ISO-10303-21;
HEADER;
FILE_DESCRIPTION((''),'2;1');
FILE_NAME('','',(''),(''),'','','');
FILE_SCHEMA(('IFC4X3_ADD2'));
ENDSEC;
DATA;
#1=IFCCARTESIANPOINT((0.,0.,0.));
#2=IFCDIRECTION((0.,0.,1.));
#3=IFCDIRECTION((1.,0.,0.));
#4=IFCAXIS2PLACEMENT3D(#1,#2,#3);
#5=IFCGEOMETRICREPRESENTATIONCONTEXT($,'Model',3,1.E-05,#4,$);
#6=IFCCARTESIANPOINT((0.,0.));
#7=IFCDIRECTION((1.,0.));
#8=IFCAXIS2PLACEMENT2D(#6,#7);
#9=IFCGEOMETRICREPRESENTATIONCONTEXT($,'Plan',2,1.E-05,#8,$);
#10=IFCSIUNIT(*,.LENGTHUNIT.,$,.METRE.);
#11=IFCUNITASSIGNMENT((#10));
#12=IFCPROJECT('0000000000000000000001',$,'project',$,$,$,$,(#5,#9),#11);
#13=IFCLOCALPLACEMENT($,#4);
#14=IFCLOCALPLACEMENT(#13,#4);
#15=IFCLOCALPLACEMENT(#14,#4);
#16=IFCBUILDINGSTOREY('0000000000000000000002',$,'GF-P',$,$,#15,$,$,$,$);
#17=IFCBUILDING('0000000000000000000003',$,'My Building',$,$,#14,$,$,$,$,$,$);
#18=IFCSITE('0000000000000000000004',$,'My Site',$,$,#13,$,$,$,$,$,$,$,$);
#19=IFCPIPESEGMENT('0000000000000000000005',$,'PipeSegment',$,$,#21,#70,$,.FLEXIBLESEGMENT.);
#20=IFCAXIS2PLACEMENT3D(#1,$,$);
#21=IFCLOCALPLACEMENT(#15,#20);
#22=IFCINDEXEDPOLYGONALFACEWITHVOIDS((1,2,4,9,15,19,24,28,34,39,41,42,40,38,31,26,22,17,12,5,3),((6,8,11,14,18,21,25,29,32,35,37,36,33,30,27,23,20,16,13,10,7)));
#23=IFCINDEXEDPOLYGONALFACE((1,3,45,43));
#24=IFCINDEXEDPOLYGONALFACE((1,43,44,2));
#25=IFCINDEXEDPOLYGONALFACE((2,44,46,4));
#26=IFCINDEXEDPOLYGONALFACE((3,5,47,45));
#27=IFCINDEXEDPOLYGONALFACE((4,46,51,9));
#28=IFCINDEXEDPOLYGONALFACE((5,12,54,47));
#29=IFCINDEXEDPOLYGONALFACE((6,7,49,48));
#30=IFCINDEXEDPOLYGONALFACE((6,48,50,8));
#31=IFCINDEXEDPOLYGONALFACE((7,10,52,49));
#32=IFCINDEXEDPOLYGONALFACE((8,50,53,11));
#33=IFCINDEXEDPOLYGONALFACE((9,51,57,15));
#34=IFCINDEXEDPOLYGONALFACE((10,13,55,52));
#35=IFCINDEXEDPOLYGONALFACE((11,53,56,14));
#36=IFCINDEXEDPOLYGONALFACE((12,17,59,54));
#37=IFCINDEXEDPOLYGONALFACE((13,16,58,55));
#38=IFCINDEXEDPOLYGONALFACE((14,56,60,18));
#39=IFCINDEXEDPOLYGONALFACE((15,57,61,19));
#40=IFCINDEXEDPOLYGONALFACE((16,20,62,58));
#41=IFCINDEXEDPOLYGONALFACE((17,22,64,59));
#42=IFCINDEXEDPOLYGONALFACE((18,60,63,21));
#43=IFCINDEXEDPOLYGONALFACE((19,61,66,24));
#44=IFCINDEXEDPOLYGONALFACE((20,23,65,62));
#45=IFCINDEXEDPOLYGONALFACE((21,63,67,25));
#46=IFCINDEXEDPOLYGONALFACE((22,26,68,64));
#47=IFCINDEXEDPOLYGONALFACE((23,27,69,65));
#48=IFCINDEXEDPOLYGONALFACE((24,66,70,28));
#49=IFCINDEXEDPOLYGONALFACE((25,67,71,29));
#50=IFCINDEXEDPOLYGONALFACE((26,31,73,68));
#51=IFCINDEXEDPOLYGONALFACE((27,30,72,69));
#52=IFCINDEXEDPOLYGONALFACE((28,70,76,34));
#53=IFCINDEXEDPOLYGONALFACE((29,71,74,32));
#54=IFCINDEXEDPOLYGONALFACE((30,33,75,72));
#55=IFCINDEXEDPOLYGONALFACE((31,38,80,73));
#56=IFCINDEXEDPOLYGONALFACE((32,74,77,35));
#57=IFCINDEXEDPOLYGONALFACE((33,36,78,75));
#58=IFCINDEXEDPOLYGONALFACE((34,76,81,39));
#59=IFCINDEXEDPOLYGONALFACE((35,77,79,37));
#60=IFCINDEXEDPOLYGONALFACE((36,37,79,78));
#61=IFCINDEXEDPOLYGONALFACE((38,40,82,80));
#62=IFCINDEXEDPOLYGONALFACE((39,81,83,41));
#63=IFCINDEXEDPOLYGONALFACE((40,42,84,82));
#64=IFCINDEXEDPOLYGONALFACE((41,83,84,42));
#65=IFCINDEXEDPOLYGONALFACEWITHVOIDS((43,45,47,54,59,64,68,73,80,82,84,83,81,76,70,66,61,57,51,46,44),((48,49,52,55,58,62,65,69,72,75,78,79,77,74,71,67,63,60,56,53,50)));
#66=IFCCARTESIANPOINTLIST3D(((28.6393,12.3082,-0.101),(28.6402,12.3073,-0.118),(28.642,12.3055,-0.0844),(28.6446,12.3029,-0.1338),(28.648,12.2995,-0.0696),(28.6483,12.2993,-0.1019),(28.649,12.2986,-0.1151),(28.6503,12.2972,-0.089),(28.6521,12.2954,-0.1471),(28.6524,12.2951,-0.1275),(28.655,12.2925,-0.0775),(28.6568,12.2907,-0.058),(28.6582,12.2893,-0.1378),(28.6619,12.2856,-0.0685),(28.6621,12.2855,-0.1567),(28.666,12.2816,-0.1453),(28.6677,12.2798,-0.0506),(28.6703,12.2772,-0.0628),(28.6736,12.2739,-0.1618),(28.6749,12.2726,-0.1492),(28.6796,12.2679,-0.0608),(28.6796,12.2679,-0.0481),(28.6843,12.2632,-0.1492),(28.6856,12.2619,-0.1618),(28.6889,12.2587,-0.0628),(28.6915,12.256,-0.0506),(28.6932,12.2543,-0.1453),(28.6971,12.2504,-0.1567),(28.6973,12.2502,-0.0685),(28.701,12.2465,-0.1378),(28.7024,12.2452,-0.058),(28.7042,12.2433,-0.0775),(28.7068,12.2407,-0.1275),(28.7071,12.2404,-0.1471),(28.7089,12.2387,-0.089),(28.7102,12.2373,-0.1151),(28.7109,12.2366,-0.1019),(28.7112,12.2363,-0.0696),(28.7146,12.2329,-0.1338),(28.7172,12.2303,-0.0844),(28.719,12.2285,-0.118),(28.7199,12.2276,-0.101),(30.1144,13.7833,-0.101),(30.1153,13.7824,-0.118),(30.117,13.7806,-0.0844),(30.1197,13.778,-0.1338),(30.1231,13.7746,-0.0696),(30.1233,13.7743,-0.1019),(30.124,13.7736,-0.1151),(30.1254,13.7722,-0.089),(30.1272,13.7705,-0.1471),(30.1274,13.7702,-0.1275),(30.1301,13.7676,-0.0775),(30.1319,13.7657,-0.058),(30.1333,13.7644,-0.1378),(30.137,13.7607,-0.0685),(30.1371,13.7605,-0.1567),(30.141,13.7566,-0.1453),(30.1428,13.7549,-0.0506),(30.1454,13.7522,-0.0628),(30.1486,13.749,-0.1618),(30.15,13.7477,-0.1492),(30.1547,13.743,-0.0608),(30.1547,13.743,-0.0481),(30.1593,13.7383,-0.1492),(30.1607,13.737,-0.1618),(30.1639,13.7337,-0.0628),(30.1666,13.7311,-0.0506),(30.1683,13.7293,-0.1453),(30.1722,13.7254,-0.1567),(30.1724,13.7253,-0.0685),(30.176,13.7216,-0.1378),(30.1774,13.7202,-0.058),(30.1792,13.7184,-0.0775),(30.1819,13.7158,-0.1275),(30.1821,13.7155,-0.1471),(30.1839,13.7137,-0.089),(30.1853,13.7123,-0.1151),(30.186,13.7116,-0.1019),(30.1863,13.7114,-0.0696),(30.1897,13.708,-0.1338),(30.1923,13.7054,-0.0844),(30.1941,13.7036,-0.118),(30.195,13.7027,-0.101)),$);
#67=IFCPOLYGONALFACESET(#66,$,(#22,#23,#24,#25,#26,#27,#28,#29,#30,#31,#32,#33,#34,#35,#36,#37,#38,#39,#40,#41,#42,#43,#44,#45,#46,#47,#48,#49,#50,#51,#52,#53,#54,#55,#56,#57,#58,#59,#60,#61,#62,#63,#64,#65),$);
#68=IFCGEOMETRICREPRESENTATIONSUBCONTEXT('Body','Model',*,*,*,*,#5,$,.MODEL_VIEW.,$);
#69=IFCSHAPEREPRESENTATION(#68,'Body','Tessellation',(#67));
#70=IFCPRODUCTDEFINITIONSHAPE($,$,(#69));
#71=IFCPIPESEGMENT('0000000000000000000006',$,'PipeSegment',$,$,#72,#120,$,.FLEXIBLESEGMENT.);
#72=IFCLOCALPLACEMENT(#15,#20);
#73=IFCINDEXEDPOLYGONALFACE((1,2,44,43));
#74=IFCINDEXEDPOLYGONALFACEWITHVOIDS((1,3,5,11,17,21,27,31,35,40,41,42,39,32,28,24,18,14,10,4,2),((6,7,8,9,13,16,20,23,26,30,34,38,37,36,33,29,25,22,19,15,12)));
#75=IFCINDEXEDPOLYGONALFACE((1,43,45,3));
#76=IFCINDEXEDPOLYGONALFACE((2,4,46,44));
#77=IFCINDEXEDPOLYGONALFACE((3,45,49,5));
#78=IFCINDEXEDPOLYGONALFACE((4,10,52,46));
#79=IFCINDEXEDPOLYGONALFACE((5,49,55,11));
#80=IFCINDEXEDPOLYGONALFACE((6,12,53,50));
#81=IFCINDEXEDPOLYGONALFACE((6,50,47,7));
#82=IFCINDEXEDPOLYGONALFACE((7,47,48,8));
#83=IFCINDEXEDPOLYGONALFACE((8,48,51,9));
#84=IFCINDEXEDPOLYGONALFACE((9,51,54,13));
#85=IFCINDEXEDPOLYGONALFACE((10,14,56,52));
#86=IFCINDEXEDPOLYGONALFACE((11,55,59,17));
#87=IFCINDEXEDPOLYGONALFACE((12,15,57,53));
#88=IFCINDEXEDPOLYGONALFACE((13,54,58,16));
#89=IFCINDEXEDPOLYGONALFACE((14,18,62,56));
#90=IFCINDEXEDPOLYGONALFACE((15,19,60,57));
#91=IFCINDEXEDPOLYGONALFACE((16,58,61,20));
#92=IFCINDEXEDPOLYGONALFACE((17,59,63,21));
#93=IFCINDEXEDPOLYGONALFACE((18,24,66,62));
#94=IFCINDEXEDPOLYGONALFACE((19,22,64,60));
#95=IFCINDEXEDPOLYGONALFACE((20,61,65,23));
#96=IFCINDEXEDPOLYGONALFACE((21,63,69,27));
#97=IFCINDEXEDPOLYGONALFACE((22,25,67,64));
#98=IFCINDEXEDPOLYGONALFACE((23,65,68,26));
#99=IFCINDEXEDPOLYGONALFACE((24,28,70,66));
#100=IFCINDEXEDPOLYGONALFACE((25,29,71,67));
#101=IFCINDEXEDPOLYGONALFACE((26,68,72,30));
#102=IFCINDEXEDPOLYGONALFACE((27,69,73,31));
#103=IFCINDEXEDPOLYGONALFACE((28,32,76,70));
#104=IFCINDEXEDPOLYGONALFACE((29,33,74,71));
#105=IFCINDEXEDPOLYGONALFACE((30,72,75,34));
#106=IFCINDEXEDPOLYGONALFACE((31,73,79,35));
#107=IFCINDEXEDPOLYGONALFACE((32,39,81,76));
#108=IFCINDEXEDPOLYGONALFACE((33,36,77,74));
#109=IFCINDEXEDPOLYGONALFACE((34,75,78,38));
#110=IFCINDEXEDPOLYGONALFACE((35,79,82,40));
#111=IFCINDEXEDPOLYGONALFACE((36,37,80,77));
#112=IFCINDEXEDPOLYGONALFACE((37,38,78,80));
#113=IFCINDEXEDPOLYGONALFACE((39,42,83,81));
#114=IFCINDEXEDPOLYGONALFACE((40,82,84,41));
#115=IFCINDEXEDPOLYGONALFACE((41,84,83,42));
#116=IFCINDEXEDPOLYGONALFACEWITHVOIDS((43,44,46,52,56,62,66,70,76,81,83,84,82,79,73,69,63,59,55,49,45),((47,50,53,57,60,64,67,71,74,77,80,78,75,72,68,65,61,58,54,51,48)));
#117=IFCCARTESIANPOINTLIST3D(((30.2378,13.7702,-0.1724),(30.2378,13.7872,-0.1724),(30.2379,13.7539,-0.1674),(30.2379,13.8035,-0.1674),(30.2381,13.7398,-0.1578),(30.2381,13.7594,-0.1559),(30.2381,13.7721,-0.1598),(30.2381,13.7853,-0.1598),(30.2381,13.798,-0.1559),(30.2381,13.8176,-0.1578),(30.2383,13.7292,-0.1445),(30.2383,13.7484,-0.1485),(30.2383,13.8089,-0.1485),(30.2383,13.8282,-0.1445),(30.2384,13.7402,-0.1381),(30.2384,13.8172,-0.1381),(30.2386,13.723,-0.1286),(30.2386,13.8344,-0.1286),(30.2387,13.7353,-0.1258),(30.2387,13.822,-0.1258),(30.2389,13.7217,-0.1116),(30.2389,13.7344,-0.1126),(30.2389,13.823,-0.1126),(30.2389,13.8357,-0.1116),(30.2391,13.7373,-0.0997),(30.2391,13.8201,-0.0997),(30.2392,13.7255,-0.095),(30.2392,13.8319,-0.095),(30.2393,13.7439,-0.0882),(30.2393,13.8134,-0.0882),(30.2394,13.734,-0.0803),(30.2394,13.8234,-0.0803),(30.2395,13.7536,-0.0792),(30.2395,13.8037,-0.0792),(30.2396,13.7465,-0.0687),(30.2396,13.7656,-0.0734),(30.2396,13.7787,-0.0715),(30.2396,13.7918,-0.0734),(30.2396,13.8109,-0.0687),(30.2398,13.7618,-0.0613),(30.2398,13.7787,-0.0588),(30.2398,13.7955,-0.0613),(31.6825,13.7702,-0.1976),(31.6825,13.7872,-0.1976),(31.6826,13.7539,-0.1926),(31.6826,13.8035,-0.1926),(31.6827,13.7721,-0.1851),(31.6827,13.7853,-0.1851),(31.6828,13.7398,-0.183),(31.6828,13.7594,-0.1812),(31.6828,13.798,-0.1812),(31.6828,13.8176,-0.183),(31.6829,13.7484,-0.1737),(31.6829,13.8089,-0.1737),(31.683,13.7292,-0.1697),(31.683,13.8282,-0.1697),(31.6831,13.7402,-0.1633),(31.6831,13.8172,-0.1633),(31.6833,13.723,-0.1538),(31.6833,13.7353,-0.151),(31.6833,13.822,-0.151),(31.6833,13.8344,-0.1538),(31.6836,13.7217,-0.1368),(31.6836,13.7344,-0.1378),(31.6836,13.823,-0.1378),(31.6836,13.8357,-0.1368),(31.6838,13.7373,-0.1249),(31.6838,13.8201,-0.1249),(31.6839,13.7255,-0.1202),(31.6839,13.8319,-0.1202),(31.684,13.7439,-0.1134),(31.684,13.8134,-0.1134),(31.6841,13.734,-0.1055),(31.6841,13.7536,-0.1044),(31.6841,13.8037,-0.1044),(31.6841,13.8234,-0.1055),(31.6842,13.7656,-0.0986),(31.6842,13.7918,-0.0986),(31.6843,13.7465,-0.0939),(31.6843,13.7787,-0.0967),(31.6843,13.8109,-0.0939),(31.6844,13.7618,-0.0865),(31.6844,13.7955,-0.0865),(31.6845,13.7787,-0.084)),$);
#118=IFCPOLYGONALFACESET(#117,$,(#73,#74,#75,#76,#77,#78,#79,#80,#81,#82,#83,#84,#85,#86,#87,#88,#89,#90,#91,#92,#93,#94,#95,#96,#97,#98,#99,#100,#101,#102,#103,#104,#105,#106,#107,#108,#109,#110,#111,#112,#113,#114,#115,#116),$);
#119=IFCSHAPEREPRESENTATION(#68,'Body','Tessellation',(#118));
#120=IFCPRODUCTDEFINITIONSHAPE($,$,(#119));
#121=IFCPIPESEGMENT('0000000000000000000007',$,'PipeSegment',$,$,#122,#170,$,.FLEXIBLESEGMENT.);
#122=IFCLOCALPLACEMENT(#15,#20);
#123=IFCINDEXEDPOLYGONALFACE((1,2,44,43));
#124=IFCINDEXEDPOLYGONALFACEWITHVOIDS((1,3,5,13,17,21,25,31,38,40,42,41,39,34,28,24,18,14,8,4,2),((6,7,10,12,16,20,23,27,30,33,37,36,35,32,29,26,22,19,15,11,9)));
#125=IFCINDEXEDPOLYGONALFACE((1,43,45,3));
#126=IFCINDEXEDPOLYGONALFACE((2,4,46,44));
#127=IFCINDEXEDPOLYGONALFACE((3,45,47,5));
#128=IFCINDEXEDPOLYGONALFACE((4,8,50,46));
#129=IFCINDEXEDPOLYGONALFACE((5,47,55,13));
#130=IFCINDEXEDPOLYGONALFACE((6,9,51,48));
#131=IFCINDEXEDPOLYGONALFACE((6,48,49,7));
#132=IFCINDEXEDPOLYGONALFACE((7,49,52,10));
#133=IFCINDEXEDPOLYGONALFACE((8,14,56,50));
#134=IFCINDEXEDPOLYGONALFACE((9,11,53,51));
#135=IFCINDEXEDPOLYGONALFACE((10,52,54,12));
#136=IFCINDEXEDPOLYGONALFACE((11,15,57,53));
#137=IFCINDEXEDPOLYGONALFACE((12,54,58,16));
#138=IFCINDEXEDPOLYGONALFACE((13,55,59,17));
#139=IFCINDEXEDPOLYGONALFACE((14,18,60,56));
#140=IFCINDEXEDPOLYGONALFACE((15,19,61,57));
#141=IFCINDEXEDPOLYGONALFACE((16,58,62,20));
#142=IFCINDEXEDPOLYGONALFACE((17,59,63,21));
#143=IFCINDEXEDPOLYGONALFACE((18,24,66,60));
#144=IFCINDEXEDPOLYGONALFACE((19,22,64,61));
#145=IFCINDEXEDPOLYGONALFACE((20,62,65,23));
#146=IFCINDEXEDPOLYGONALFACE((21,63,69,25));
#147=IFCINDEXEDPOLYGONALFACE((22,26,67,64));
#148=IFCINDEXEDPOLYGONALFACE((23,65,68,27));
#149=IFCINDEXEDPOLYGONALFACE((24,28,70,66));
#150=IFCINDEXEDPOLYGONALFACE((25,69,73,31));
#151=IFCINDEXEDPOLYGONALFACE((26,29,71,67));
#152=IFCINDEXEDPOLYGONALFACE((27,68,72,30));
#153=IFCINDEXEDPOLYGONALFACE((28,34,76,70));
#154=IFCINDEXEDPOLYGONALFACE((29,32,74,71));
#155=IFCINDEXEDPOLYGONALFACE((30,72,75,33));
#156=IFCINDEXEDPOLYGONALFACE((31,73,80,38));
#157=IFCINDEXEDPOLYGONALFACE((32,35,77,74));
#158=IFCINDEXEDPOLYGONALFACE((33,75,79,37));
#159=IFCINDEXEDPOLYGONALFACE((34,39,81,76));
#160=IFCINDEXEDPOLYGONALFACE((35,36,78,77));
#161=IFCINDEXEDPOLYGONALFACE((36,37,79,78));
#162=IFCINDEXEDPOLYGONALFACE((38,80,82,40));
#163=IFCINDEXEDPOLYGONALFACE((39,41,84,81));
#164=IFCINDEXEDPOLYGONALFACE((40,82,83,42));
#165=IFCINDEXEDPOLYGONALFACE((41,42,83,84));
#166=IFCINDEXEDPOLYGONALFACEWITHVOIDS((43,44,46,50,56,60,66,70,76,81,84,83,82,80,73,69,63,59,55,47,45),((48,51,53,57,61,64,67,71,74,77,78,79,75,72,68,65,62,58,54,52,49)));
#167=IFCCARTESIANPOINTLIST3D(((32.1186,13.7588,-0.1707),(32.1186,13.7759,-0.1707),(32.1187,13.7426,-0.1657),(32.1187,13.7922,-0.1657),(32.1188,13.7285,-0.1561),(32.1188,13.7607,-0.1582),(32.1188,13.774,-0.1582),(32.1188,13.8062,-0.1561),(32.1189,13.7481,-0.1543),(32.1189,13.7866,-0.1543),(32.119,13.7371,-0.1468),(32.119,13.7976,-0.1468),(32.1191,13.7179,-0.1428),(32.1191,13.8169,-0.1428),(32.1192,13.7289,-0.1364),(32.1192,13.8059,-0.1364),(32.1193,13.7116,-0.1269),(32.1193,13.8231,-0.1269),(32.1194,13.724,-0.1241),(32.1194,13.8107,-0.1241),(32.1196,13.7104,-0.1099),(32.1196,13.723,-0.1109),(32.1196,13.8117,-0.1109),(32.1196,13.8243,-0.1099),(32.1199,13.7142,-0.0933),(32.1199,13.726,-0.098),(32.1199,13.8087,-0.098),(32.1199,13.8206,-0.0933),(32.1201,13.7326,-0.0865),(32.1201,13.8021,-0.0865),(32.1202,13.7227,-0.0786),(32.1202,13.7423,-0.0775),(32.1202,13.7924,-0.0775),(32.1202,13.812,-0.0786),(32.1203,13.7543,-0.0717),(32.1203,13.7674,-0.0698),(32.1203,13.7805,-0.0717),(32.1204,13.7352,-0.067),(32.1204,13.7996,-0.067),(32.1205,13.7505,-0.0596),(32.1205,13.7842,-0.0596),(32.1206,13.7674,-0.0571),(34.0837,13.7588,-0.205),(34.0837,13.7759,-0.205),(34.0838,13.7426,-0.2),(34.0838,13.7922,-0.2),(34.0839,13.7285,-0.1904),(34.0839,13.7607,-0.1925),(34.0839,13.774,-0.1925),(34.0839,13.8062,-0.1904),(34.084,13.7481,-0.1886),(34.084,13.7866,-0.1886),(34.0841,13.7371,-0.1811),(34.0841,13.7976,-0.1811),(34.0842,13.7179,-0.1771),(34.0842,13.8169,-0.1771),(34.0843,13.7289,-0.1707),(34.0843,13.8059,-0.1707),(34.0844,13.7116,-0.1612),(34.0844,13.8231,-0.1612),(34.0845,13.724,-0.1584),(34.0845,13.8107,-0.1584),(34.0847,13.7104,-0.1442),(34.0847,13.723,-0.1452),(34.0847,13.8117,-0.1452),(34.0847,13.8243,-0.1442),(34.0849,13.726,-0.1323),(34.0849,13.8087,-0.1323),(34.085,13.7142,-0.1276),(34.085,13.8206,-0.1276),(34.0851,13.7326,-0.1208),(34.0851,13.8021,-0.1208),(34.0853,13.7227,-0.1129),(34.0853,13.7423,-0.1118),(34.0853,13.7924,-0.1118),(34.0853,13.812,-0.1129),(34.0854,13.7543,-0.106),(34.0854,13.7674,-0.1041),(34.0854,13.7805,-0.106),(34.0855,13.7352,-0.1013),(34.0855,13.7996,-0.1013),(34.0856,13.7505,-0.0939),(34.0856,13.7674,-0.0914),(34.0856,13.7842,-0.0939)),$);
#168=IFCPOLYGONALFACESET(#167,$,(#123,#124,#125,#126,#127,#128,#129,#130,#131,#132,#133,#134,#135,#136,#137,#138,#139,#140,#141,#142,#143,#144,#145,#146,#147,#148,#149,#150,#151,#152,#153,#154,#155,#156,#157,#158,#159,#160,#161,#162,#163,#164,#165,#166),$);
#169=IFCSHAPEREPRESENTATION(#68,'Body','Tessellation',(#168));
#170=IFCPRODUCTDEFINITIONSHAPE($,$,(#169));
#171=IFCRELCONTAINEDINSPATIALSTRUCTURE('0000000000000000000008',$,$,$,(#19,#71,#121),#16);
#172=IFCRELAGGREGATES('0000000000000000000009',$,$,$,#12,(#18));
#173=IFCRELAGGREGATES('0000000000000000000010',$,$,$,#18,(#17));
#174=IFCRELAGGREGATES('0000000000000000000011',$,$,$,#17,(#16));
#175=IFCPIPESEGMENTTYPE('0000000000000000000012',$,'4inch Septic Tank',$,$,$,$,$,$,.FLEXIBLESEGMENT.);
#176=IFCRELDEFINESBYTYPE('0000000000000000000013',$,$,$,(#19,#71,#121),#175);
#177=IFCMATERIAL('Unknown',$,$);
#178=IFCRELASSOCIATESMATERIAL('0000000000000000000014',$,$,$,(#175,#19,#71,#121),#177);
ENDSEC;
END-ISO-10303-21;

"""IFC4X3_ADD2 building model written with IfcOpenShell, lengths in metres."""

from ifc_helpers import new_model, si_unit, frame, origin_with_axes, origin_2d_with_axis, place, context, subcontext, project, spatial, hollow_circle, extrude, material, material_profile, profile_set, profile_usage, type_object, element, save


model = new_model("IFC4X3_ADD2")

# Units and contexts
model_context = context("Model", 3, precision=1e-05, world=origin_with_axes())
plan_context = context("Plan", 2, precision=1e-05, world=origin_2d_with_axis())
body_context = subcontext(model_context, "Body", "Model", "MODEL_VIEW")
ifc_project = project(units=[si_unit("LENGTHUNIT", "METRE")], contexts=[model_context, plan_context])

# Site, building, storey
site_placement = place(None, origin_with_axes())
site = spatial("IfcSite", under=ifc_project, at=site_placement, Name="My Site")
building_placement = place(site_placement, origin_with_axes())
building = spatial("IfcBuilding", under=site, at=building_placement, Name="My Building")
storey_placement = place(building_placement, origin_with_axes())
storey = spatial("IfcBuildingStorey", under=building, at=storey_placement, Name="GF-P")

# Pipe segments
ifc_material_1 = material(Name="Unknown")
ifc_material_profile_1 = material_profile(ifc_material_1, hollow_circle(Radius=0.0571, WallThickness=0.0127))
ifc_profile_set_1 = profile_set([ifc_material_profile_1], Name="blackwater")
pipe_segment_type_1 = type_object("IfcPipeSegmentType", Name="4inch Septic Tank", PredefinedType="FLEXIBLESEGMENT", material=ifc_profile_set_1)
ifc_profile_usage_1 = profile_usage(ifc_profile_set_1, cardinal=5)
pipe_segment_1_placement = place(storey_placement, frame((28.6796, 12.2679, -0.1052), z_axis=(0.707107, 0.707107, 0.0), x_axis=(0.000001, 0.0, 1.0)))
element("IfcPipeSegment", 1, at=pipe_segment_1_placement, inside=storey, type_object=pipe_segment_type_1, material=ifc_profile_usage_1, Name="PipeSegment", PredefinedType="FLEXIBLESEGMENT", context=body_context, shape_type="SweptSolid", body=[
    extrude(hollow_circle(Radius=0.0571, WallThickness=0.0127), origin_with_axes(), (0.0, 0.0, 1.0), 2.086),
])
ifc_profile_usage_2 = profile_usage(ifc_profile_set_1, cardinal=5)
pipe_segment_2_placement = place(storey_placement, frame((30.2388, 13.7787, -0.1159), z_axis=(0.999848, 0.0, -0.017452), x_axis=(0.017452, 0.0, 0.999848)))
element("IfcPipeSegment", 2, at=pipe_segment_2_placement, inside=storey, type_object=pipe_segment_type_1, material=ifc_profile_usage_2, Name="PipeSegment", PredefinedType="FLEXIBLESEGMENT", context=body_context, shape_type="SweptSolid", body=[
    extrude(hollow_circle(Radius=0.0571, WallThickness=0.0127), origin_with_axes(), (0.0, 0.0, 1.0), 1.4449),
])
ifc_profile_usage_3 = profile_usage(ifc_profile_set_1, cardinal=5)
pipe_segment_3_placement = place(storey_placement, frame((32.1196, 13.7674, -0.1142), z_axis=(0.999848, 0.0, -0.017452), x_axis=(0.017452, 0.0, 0.999848)))
element("IfcPipeSegment", 3, at=pipe_segment_3_placement, inside=storey, type_object=pipe_segment_type_1, material=ifc_profile_usage_3, Name="PipeSegment", PredefinedType="FLEXIBLESEGMENT", context=body_context, shape_type="SweptSolid", body=[
    extrude(hollow_circle(Radius=0.0571, WallThickness=0.0127), origin_with_axes(), (0.0, 0.0, 1.0), 1.9654),
])

save(model, "model.ifc")
